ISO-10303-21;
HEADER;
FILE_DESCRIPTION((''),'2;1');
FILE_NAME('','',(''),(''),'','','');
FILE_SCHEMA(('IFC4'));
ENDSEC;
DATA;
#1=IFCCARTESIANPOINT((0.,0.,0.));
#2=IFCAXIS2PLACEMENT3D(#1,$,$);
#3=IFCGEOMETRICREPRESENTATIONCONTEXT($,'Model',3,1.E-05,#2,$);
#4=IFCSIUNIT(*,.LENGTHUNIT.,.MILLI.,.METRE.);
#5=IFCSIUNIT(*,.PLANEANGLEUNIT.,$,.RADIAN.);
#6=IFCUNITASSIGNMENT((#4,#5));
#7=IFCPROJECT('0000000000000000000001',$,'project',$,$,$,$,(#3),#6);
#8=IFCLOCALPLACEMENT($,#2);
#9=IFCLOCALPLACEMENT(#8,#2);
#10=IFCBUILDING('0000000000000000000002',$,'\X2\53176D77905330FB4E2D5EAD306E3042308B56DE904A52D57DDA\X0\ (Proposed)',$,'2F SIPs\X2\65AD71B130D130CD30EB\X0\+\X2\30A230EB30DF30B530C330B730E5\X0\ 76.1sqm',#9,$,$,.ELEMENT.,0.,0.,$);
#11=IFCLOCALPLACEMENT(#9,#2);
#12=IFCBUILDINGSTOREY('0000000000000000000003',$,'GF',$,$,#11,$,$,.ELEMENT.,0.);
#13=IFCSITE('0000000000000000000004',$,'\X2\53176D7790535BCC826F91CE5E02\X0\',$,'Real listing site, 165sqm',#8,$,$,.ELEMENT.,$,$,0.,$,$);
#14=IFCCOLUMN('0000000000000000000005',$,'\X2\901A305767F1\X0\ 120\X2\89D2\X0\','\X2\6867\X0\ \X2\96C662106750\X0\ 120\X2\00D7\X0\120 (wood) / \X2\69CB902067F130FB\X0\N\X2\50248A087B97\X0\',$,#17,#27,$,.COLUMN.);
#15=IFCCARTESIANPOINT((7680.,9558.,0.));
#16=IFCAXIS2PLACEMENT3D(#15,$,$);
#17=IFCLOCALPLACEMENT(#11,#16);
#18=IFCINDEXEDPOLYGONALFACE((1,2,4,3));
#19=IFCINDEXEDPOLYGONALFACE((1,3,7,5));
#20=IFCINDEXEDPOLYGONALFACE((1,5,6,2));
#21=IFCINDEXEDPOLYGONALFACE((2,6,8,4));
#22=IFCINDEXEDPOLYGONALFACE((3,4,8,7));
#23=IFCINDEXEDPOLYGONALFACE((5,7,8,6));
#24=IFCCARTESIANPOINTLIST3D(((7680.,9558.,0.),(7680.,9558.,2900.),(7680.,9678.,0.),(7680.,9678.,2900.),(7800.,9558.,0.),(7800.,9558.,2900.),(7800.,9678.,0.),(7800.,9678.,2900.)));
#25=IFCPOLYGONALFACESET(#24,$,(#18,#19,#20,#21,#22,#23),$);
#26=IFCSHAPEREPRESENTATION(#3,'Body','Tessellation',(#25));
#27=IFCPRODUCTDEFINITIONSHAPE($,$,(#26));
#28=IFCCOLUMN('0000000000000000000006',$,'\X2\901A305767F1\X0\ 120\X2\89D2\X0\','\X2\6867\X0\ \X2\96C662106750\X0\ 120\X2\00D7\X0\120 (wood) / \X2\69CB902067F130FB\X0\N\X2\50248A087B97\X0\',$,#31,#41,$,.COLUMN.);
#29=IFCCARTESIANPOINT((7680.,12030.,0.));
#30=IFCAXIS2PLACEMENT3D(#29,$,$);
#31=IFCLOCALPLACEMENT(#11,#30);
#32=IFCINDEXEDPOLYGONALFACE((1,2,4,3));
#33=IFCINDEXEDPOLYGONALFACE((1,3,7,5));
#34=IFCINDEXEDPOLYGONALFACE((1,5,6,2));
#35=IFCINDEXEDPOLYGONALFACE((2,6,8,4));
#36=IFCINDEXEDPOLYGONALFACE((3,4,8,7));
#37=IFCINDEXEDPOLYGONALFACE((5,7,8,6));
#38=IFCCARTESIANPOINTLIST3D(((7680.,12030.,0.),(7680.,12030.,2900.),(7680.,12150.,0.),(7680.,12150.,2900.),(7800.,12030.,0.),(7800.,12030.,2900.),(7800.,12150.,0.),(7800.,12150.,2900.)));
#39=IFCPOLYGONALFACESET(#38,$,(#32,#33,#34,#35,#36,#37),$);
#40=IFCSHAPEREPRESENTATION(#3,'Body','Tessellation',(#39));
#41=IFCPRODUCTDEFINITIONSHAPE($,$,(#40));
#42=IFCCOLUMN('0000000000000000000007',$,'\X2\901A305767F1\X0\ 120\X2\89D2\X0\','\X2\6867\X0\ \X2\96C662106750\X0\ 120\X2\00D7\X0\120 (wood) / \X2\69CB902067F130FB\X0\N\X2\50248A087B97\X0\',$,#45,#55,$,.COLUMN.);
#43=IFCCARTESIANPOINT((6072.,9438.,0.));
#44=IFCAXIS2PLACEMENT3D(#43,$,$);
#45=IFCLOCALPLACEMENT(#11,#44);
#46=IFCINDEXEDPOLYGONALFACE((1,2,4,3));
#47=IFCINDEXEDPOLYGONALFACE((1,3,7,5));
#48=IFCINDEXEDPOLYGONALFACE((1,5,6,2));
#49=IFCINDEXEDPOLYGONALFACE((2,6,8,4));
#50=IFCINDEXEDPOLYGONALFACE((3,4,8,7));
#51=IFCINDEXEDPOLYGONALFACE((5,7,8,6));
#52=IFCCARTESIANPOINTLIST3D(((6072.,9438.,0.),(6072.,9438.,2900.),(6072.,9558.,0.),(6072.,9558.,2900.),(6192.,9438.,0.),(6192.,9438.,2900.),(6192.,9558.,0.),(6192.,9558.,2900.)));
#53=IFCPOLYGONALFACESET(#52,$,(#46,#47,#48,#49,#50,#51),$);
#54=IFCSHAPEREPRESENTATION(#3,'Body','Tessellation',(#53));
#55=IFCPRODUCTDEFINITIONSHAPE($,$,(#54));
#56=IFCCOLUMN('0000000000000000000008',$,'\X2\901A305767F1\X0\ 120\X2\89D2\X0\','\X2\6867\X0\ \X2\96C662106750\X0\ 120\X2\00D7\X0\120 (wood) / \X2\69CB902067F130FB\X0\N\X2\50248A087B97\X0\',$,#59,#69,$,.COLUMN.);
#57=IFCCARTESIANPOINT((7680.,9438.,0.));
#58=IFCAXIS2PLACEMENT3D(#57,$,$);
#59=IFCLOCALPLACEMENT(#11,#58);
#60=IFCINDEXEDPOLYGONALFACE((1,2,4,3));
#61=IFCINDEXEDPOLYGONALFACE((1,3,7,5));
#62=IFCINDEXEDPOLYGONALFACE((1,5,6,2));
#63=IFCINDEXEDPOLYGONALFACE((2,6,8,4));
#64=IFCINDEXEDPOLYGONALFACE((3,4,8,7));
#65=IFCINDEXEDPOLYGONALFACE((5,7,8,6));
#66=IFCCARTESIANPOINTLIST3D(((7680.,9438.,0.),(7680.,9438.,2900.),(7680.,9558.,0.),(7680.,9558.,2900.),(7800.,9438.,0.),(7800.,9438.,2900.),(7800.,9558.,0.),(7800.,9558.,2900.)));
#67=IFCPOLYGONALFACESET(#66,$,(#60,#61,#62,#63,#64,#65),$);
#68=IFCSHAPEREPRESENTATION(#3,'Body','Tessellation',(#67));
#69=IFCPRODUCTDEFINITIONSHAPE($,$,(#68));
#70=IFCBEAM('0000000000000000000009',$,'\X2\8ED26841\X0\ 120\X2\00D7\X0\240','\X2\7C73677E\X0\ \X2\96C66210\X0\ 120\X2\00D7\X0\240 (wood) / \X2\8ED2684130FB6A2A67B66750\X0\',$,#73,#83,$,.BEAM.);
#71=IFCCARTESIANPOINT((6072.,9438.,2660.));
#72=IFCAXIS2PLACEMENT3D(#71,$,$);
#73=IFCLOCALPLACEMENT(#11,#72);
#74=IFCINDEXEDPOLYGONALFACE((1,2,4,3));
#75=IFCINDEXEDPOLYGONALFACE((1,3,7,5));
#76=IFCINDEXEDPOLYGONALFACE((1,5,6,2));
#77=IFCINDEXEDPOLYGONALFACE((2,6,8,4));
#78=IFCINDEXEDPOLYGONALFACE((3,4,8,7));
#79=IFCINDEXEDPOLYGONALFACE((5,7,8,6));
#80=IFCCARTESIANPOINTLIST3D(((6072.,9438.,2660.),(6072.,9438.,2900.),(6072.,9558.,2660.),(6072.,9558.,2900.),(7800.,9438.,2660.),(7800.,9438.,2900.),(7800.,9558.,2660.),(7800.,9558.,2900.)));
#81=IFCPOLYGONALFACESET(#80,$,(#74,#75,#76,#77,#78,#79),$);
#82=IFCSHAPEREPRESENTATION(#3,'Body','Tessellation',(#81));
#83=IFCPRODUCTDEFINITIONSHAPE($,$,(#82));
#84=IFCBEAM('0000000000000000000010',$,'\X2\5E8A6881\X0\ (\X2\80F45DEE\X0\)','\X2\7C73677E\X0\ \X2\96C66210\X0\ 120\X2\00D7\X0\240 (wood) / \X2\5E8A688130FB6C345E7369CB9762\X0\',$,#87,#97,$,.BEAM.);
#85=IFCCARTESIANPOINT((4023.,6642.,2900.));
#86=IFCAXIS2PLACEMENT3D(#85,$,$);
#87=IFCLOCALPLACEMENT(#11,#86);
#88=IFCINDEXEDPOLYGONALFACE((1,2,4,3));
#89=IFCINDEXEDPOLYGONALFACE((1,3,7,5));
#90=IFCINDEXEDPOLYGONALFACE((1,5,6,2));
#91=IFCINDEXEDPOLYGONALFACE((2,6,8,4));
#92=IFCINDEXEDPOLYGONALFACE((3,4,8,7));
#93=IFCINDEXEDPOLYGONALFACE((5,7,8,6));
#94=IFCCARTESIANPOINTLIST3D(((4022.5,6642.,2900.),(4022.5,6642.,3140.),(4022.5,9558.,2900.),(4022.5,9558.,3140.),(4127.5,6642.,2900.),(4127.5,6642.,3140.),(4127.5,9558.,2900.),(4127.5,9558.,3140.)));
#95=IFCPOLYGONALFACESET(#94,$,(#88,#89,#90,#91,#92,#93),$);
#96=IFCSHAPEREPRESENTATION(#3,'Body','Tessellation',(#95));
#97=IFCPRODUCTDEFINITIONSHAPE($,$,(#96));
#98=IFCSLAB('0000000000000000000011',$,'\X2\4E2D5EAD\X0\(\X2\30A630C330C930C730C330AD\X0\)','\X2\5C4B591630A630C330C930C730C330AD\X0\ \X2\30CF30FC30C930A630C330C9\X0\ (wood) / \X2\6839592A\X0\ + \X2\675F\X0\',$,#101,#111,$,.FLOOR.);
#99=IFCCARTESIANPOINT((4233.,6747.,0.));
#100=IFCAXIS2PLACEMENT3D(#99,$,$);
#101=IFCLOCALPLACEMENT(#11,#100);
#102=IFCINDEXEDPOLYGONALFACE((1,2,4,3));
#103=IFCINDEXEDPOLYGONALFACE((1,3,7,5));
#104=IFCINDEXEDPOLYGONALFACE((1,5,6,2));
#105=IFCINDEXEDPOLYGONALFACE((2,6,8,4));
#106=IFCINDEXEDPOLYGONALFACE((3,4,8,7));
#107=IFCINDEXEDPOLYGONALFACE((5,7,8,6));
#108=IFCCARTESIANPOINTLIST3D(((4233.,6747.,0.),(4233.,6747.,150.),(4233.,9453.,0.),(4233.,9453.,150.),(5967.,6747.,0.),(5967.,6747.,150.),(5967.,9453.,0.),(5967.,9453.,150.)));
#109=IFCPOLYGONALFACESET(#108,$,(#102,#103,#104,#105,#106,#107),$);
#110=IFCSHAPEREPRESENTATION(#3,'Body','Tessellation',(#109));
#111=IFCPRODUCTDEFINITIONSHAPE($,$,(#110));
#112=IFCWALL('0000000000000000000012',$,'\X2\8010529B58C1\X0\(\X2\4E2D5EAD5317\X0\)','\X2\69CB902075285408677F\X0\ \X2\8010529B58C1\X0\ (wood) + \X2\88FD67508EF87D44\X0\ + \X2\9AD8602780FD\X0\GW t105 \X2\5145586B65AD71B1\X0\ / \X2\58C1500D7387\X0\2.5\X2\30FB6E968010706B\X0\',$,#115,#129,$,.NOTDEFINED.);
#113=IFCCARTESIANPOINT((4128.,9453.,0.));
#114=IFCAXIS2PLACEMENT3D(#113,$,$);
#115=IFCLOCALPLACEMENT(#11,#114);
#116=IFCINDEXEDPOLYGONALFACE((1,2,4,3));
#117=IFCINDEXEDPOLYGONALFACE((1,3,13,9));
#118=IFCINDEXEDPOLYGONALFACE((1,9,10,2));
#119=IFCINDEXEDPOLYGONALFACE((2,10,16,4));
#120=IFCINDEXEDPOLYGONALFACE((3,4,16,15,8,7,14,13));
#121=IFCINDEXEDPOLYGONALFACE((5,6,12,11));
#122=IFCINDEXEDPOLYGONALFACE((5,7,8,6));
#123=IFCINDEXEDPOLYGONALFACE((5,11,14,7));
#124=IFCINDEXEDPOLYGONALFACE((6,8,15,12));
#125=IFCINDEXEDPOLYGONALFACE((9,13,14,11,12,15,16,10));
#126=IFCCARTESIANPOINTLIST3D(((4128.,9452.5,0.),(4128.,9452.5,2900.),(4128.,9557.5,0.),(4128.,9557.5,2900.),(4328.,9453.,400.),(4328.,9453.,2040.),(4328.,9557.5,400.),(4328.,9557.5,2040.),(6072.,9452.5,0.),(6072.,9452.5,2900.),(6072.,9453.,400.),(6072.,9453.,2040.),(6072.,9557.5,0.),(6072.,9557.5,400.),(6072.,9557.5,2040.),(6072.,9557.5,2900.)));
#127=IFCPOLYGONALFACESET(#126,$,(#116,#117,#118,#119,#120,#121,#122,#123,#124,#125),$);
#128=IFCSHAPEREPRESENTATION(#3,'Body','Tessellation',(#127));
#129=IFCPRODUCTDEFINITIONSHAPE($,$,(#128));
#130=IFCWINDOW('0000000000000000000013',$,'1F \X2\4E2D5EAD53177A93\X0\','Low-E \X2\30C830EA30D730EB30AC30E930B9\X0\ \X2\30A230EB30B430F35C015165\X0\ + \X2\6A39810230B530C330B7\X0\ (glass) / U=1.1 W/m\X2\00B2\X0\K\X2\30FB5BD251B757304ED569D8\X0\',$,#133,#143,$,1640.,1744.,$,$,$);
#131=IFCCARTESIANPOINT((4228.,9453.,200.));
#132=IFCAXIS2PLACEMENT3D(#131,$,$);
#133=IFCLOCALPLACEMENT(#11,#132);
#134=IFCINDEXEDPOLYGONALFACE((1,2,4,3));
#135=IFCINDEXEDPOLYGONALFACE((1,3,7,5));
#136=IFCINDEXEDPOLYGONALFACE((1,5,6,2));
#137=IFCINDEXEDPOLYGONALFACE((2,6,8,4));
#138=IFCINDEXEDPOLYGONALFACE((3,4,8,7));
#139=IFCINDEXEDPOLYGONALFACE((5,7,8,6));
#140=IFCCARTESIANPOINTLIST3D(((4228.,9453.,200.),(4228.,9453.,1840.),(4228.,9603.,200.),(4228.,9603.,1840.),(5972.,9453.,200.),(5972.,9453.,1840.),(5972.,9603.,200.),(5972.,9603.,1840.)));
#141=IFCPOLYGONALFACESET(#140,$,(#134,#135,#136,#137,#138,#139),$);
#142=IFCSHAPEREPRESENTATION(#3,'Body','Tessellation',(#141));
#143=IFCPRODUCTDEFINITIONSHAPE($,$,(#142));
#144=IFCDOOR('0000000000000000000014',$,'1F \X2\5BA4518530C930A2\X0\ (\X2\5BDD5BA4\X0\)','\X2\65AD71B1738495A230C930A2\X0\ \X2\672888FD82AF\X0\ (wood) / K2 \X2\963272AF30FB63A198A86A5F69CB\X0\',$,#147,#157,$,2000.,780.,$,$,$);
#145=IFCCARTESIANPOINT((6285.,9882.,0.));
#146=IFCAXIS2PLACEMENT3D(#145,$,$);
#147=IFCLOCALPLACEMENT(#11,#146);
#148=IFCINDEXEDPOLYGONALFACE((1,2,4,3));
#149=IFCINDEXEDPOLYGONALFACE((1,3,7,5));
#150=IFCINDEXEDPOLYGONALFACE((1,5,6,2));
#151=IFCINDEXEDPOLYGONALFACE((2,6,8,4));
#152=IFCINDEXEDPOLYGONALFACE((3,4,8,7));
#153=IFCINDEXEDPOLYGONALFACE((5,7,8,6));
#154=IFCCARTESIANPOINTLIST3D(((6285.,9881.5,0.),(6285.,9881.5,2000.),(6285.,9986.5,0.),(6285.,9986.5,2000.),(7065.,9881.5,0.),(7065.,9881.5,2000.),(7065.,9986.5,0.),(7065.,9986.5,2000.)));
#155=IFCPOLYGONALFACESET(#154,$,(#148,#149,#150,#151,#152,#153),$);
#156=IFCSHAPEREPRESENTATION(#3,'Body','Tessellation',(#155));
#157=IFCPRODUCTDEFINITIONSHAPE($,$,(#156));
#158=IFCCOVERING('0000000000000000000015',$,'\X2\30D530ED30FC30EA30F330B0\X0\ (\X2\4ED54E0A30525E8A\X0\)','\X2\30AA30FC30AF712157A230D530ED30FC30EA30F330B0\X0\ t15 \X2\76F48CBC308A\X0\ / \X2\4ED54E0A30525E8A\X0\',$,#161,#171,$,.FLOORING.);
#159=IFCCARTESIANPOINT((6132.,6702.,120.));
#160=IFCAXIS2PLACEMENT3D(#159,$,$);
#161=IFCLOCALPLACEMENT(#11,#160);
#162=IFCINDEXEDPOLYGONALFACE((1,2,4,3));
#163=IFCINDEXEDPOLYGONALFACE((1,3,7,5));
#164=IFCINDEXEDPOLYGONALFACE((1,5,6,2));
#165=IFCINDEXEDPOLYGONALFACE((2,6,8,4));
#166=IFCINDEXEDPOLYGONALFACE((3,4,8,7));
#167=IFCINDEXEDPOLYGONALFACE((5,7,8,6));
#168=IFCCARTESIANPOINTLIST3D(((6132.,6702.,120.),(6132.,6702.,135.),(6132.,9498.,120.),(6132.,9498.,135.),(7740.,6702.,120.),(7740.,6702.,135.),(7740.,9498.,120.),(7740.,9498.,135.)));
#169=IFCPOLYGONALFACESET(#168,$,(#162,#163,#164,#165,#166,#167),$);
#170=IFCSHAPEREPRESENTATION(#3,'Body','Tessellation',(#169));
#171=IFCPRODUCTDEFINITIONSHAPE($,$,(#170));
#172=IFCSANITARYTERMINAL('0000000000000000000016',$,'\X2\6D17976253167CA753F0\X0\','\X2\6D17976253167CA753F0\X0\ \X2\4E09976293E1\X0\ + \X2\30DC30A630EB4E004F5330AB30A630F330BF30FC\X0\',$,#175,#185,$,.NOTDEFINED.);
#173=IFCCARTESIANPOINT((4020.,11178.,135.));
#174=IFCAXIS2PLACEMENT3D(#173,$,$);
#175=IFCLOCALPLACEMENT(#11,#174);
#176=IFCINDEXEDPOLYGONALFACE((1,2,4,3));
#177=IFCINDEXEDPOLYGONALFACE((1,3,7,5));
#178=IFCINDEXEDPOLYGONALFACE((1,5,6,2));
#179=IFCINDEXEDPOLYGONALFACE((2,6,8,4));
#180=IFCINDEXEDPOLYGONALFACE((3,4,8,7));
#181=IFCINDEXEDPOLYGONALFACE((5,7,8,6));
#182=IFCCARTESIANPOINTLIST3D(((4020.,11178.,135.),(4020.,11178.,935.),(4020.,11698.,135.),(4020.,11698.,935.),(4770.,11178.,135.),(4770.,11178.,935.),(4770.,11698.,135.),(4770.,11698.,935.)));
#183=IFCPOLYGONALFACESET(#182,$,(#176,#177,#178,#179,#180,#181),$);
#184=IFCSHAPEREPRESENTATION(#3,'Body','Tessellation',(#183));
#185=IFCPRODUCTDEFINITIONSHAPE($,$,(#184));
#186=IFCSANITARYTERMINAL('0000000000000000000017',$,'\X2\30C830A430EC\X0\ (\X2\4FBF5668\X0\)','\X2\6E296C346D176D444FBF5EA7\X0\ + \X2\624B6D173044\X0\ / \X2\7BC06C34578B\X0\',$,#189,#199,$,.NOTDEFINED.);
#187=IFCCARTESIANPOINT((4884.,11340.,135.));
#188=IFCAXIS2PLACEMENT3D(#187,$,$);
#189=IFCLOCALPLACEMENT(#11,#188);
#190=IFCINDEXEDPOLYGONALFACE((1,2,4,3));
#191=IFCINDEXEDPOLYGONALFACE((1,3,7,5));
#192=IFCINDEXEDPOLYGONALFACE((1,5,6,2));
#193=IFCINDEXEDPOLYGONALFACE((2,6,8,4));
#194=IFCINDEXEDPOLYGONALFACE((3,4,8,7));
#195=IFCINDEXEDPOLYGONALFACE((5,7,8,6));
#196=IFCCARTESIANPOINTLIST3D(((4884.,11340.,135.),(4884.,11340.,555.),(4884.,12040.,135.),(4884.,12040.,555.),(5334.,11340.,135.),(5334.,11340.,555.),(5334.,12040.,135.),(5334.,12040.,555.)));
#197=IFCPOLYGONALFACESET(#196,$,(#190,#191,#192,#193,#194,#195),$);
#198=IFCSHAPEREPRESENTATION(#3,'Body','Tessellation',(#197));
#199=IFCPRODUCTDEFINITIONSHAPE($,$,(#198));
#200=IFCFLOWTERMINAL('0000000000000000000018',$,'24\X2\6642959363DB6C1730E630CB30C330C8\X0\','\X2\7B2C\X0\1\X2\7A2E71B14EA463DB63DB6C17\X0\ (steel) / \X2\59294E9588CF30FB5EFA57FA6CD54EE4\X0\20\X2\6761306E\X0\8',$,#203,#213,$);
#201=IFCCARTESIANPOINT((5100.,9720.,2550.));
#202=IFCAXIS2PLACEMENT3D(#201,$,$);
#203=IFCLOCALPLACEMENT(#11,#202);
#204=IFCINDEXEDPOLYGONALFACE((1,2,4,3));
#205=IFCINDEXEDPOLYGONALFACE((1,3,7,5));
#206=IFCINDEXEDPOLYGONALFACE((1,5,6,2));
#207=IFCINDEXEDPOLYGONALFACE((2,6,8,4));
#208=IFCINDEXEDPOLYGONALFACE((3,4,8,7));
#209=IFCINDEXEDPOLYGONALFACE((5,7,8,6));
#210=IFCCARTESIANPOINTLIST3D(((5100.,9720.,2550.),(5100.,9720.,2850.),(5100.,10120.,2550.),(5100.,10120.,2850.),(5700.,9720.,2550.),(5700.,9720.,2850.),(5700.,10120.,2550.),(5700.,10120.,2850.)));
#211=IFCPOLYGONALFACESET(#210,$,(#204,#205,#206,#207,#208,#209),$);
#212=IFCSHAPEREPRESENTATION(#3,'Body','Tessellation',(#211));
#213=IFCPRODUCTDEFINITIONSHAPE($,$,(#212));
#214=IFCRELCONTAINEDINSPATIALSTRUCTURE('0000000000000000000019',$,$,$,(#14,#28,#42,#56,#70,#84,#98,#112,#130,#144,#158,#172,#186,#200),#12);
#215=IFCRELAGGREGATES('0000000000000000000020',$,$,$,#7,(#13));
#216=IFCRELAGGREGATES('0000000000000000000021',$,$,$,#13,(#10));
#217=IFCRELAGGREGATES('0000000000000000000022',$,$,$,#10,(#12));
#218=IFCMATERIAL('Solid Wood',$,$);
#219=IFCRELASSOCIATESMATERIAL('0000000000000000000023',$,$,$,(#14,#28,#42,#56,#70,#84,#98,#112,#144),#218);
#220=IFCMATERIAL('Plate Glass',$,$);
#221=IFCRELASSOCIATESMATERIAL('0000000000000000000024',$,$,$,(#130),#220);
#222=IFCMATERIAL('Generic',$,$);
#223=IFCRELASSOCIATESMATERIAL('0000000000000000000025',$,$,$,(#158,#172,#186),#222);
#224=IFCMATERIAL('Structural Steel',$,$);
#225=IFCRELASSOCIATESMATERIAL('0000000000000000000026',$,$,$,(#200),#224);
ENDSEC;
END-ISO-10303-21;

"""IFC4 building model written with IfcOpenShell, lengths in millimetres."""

from ifc_helpers import new_model, si_unit, frame, frame_2d, origin, place, context, project, spatial, rectangle, extrude, material, element, fill, save


model = new_model("IFC4")

# Units and contexts
model_context = context("Model", 3, precision=1e-05, world=origin())
ifc_project = project(units=[si_unit("LENGTHUNIT", "METRE", prefix="MILLI"), si_unit("PLANEANGLEUNIT", "RADIAN")], contexts=[model_context])

# Site, building, storey
site_placement = place(None, origin())
site = spatial("IfcSite", under=ifc_project, at=site_placement, Name="北海道富良野市", ObjectType="Real listing site, 165sqm", CompositionType="ELEMENT", RefElevation=0.0)
building_placement = place(site_placement, origin())
building = spatial("IfcBuilding", under=site, at=building_placement, Name="北海道・中庭のある回遊動線 (Proposed)", ObjectType="2F SIPs断熱パネル+アルミサッシュ 76.1sqm", CompositionType="ELEMENT", ElevationOfRefHeight=0.0, ElevationOfTerrain=0.0)
storey_placement = place(building_placement, origin())
storey = spatial("IfcBuildingStorey", under=building, at=storey_placement, Name="GF", CompositionType="ELEMENT", Elevation=0.0)

# Columns
ifc_material_1 = material(Name="Solid Wood")
column_1_placement = place(storey_placement, frame((7680.0, 9558.0, 0.0)))
element("IfcColumn", 1, at=column_1_placement, inside=storey, material=ifc_material_1, Name="通し柱 120角", Description="桧 集成材 120×120 (wood) / 構造柱・N値計算", PredefinedType="COLUMN", context=model_context, shape_type="SweptSolid", body=[
    extrude(rectangle(XDim=120.0, YDim=120.0, at=frame_2d((60.0, 60.0))), frame((7680.0, 9558.0, 0.0)), (0.0, 0.0, 1.0), 2900.0),
])
column_2_placement = place(storey_placement, frame((7680.0, 12030.0, 0.0)))
element("IfcColumn", 2, at=column_2_placement, inside=storey, material=ifc_material_1, Name="通し柱 120角", Description="桧 集成材 120×120 (wood) / 構造柱・N値計算", PredefinedType="COLUMN", context=model_context, shape_type="SweptSolid", body=[
    extrude(rectangle(XDim=120.0, YDim=120.0, at=frame_2d((60.0, 60.0))), frame((7680.0, 12030.0, 0.0)), (0.0, 0.0, 1.0), 2900.0),
])
column_3_placement = place(storey_placement, frame((6072.0, 9438.0, 0.0)))
element("IfcColumn", 3, at=column_3_placement, inside=storey, material=ifc_material_1, Name="通し柱 120角", Description="桧 集成材 120×120 (wood) / 構造柱・N値計算", PredefinedType="COLUMN", context=model_context, shape_type="SweptSolid", body=[
    extrude(rectangle(XDim=120.0, YDim=120.0, at=frame_2d((60.0, 60.0))), frame((6072.0, 9438.0, 0.0)), (0.0, 0.0, 1.0), 2900.0),
])
column_4_placement = place(storey_placement, frame((7680.0, 9438.0, 0.0)))
element("IfcColumn", 4, at=column_4_placement, inside=storey, material=ifc_material_1, Name="通し柱 120角", Description="桧 集成材 120×120 (wood) / 構造柱・N値計算", PredefinedType="COLUMN", context=model_context, shape_type="SweptSolid", body=[
    extrude(rectangle(XDim=120.0, YDim=120.0, at=frame_2d((60.0, 60.0))), frame((7680.0, 9438.0, 0.0)), (0.0, 0.0, 1.0), 2900.0),
])

# Beams
beam_1_placement = place(storey_placement, frame((6072.0, 9438.0, 2660.0)))
element("IfcBeam", 5, at=beam_1_placement, inside=storey, material=ifc_material_1, Name="軒桁 120×240", Description="米松 集成 120×240 (wood) / 軒桁・横架材", PredefinedType="BEAM", context=model_context, shape_type="SweptSolid", body=[
    extrude(rectangle(XDim=1728.0, YDim=120.0, at=frame_2d((864.0, 60.0))), frame((6072.0, 9438.0, 2660.0)), (0.0, 0.0, 1.0), 240.0),
])
beam_2_placement = place(storey_placement, frame((4023.0, 6642.0, 2900.0)))
element("IfcBeam", 6, at=beam_2_placement, inside=storey, material=ifc_material_1, Name="床梁 (胴差)", Description="米松 集成 120×240 (wood) / 床梁・水平構面", PredefinedType="BEAM", context=model_context, shape_type="SweptSolid", body=[
    extrude(rectangle(XDim=105.0, YDim=2916.0, at=frame_2d((52.0, 1458.0))), frame((4023.0, 6642.0, 2900.0)), (0.0, 0.0, 1.0), 240.0),
])

# Slab
slab_placement = place(storey_placement, frame((4233.0, 6747.0, 0.0)))
element("IfcSlab", 7, at=slab_placement, inside=storey, material=ifc_material_1, Name="中庭(ウッドデッキ)", Description="屋外ウッドデッキ ハードウッド (wood) / 根太 + 束", PredefinedType="FLOOR", context=model_context, shape_type="SweptSolid", body=[
    extrude(rectangle(XDim=1734.0, YDim=2706.0, at=frame_2d((867.0, 1353.0))), frame((4233.0, 6747.0, 0.0)), (0.0, 0.0, 1.0), 150.0),
])

# Wall, opening, window
wall_1_placement = place(storey_placement, frame((4128.0, 9453.0, 0.0)))
wall_1 = element("IfcWall", 8, at=wall_1_placement, inside=storey, material=ifc_material_1, Name="耐力壁(中庭北)", Description="構造用合板 耐力壁 (wood) + 製材軸組 + 高性能GW t105 充填断熱 / 壁倍率2.5・準耐火", PredefinedType="NOTDEFINED", context=model_context, shape_type="SweptSolid", body=[
    extrude(rectangle(XDim=1944.0, YDim=105.0, at=frame_2d((972.0, 52.0))), frame((4128.0, 9453.0, 0.0)), (0.0, 0.0, 1.0), 2900.0),
])
opening_placement = place(storey_placement, frame((4228.0, 9453.0, 200.0)))
opening = element("IfcOpeningElement", 9, at=opening_placement, cuts=wall_1, PredefinedType="NOTDEFINED", context=model_context, shape_type="SweptSolid", body=[
    extrude(rectangle(XDim=1744.0, YDim=150.0, at=frame_2d((872.0, 75.0))), frame((4228.0, 9453.0, 200.0)), (0.0, 0.0, 1.0), 1640.0),
])
ifc_material_2 = material(Name="Plate Glass")
window_placement = place(storey_placement, frame((4228.0, 9453.0, 200.0)))
window = element("IfcWindow", 10, at=window_placement, inside=storey, material=ifc_material_2, Name="1F 中庭北窓", Description="Low-E トリプルガラス アルゴン封入 + 樹脂サッシ (glass) / U=1.1 W/m²K・寒冷地仕様", OverallHeight=1640.0, OverallWidth=1744.0, context=model_context, shape_type="SweptSolid", body=[
    extrude(rectangle(XDim=1744.0, YDim=150.0, at=frame_2d((872.0, 75.0))), frame((4228.0, 9453.0, 200.0)), (0.0, 0.0, 1.0), 1640.0),
])
fill(opening, window)

# Door
door_placement = place(storey_placement, frame((6285.0, 9882.0, 0.0)))
element("IfcDoor", 11, at=door_placement, inside=storey, material=ifc_material_1, Name="1F 室内ドア (寝室)", Description="断熱玄関ドア 木製芯 (wood) / K2 防犯・採風機構", OverallHeight=2000.0, OverallWidth=780.0, context=model_context, shape_type="SweptSolid", body=[
    extrude(rectangle(XDim=780.0, YDim=105.0, at=frame_2d((390.0, 52.0))), frame((6285.0, 9882.0, 0.0)), (0.0, 0.0, 1.0), 2000.0),
])

# Covering
ifc_material_3 = material(Name="Generic")
covering_placement = place(storey_placement, frame((6132.0, 6702.0, 120.0)))
element("IfcCovering", 12, at=covering_placement, inside=storey, material=ifc_material_3, Name="フローリング (仕上げ床)", Description="オーク無垢フローリング t15 直貼り / 仕上げ床", PredefinedType="FLOORING", context=model_context, shape_type="SweptSolid", body=[
    extrude(rectangle(XDim=1608.0, YDim=2796.0, at=frame_2d((804.0, 1398.0))), frame((6132.0, 6702.0, 120.0)), (0.0, 0.0, 1.0), 15.0),
])

# Sanitary terminals
sanitary_terminal_1_placement = place(storey_placement, frame((4020.0, 11178.0, 135.0)))
element("IfcSanitaryTerminal", 13, at=sanitary_terminal_1_placement, inside=storey, material=ifc_material_3, Name="洗面化粧台", Description="洗面化粧台 三面鏡 + ボウル一体カウンター", PredefinedType="NOTDEFINED", context=model_context, shape_type="SweptSolid", body=[
    extrude(rectangle(XDim=750.0, YDim=520.0, at=frame_2d((375.0, 260.0))), frame((4020.0, 11178.0, 135.0)), (0.0, 0.0, 1.0), 800.0),
])
sanitary_terminal_2_placement = place(storey_placement, frame((4884.0, 11340.0, 135.0)))
element("IfcSanitaryTerminal", 14, at=sanitary_terminal_2_placement, inside=storey, material=ifc_material_3, Name="トイレ (便器)", Description="温水洗浄便座 + 手洗い / 節水型", PredefinedType="NOTDEFINED", context=model_context, shape_type="SweptSolid", body=[
    extrude(rectangle(XDim=450.0, YDim=700.0, at=frame_2d((225.0, 350.0))), frame((4884.0, 11340.0, 135.0)), (0.0, 0.0, 1.0), 420.0),
])

# Flow terminal
ifc_material_4 = material(Name="Structural Steel")
flow_terminal_placement = place(storey_placement, frame((5100.0, 9720.0, 2550.0)))
element("IfcFlowTerminal", 15, at=flow_terminal_placement, inside=storey, material=ifc_material_4, Name="24時間換気ユニット", Description="第1種熱交換換気 (steel) / 天井裏・建基法令20条の8", context=model_context, shape_type="SweptSolid", body=[
    extrude(rectangle(XDim=600.0, YDim=400.0, at=frame_2d((300.0, 200.0))), frame((5100.0, 9720.0, 2550.0)), (0.0, 0.0, 1.0), 300.0),
])

save(model, "model.ifc")
